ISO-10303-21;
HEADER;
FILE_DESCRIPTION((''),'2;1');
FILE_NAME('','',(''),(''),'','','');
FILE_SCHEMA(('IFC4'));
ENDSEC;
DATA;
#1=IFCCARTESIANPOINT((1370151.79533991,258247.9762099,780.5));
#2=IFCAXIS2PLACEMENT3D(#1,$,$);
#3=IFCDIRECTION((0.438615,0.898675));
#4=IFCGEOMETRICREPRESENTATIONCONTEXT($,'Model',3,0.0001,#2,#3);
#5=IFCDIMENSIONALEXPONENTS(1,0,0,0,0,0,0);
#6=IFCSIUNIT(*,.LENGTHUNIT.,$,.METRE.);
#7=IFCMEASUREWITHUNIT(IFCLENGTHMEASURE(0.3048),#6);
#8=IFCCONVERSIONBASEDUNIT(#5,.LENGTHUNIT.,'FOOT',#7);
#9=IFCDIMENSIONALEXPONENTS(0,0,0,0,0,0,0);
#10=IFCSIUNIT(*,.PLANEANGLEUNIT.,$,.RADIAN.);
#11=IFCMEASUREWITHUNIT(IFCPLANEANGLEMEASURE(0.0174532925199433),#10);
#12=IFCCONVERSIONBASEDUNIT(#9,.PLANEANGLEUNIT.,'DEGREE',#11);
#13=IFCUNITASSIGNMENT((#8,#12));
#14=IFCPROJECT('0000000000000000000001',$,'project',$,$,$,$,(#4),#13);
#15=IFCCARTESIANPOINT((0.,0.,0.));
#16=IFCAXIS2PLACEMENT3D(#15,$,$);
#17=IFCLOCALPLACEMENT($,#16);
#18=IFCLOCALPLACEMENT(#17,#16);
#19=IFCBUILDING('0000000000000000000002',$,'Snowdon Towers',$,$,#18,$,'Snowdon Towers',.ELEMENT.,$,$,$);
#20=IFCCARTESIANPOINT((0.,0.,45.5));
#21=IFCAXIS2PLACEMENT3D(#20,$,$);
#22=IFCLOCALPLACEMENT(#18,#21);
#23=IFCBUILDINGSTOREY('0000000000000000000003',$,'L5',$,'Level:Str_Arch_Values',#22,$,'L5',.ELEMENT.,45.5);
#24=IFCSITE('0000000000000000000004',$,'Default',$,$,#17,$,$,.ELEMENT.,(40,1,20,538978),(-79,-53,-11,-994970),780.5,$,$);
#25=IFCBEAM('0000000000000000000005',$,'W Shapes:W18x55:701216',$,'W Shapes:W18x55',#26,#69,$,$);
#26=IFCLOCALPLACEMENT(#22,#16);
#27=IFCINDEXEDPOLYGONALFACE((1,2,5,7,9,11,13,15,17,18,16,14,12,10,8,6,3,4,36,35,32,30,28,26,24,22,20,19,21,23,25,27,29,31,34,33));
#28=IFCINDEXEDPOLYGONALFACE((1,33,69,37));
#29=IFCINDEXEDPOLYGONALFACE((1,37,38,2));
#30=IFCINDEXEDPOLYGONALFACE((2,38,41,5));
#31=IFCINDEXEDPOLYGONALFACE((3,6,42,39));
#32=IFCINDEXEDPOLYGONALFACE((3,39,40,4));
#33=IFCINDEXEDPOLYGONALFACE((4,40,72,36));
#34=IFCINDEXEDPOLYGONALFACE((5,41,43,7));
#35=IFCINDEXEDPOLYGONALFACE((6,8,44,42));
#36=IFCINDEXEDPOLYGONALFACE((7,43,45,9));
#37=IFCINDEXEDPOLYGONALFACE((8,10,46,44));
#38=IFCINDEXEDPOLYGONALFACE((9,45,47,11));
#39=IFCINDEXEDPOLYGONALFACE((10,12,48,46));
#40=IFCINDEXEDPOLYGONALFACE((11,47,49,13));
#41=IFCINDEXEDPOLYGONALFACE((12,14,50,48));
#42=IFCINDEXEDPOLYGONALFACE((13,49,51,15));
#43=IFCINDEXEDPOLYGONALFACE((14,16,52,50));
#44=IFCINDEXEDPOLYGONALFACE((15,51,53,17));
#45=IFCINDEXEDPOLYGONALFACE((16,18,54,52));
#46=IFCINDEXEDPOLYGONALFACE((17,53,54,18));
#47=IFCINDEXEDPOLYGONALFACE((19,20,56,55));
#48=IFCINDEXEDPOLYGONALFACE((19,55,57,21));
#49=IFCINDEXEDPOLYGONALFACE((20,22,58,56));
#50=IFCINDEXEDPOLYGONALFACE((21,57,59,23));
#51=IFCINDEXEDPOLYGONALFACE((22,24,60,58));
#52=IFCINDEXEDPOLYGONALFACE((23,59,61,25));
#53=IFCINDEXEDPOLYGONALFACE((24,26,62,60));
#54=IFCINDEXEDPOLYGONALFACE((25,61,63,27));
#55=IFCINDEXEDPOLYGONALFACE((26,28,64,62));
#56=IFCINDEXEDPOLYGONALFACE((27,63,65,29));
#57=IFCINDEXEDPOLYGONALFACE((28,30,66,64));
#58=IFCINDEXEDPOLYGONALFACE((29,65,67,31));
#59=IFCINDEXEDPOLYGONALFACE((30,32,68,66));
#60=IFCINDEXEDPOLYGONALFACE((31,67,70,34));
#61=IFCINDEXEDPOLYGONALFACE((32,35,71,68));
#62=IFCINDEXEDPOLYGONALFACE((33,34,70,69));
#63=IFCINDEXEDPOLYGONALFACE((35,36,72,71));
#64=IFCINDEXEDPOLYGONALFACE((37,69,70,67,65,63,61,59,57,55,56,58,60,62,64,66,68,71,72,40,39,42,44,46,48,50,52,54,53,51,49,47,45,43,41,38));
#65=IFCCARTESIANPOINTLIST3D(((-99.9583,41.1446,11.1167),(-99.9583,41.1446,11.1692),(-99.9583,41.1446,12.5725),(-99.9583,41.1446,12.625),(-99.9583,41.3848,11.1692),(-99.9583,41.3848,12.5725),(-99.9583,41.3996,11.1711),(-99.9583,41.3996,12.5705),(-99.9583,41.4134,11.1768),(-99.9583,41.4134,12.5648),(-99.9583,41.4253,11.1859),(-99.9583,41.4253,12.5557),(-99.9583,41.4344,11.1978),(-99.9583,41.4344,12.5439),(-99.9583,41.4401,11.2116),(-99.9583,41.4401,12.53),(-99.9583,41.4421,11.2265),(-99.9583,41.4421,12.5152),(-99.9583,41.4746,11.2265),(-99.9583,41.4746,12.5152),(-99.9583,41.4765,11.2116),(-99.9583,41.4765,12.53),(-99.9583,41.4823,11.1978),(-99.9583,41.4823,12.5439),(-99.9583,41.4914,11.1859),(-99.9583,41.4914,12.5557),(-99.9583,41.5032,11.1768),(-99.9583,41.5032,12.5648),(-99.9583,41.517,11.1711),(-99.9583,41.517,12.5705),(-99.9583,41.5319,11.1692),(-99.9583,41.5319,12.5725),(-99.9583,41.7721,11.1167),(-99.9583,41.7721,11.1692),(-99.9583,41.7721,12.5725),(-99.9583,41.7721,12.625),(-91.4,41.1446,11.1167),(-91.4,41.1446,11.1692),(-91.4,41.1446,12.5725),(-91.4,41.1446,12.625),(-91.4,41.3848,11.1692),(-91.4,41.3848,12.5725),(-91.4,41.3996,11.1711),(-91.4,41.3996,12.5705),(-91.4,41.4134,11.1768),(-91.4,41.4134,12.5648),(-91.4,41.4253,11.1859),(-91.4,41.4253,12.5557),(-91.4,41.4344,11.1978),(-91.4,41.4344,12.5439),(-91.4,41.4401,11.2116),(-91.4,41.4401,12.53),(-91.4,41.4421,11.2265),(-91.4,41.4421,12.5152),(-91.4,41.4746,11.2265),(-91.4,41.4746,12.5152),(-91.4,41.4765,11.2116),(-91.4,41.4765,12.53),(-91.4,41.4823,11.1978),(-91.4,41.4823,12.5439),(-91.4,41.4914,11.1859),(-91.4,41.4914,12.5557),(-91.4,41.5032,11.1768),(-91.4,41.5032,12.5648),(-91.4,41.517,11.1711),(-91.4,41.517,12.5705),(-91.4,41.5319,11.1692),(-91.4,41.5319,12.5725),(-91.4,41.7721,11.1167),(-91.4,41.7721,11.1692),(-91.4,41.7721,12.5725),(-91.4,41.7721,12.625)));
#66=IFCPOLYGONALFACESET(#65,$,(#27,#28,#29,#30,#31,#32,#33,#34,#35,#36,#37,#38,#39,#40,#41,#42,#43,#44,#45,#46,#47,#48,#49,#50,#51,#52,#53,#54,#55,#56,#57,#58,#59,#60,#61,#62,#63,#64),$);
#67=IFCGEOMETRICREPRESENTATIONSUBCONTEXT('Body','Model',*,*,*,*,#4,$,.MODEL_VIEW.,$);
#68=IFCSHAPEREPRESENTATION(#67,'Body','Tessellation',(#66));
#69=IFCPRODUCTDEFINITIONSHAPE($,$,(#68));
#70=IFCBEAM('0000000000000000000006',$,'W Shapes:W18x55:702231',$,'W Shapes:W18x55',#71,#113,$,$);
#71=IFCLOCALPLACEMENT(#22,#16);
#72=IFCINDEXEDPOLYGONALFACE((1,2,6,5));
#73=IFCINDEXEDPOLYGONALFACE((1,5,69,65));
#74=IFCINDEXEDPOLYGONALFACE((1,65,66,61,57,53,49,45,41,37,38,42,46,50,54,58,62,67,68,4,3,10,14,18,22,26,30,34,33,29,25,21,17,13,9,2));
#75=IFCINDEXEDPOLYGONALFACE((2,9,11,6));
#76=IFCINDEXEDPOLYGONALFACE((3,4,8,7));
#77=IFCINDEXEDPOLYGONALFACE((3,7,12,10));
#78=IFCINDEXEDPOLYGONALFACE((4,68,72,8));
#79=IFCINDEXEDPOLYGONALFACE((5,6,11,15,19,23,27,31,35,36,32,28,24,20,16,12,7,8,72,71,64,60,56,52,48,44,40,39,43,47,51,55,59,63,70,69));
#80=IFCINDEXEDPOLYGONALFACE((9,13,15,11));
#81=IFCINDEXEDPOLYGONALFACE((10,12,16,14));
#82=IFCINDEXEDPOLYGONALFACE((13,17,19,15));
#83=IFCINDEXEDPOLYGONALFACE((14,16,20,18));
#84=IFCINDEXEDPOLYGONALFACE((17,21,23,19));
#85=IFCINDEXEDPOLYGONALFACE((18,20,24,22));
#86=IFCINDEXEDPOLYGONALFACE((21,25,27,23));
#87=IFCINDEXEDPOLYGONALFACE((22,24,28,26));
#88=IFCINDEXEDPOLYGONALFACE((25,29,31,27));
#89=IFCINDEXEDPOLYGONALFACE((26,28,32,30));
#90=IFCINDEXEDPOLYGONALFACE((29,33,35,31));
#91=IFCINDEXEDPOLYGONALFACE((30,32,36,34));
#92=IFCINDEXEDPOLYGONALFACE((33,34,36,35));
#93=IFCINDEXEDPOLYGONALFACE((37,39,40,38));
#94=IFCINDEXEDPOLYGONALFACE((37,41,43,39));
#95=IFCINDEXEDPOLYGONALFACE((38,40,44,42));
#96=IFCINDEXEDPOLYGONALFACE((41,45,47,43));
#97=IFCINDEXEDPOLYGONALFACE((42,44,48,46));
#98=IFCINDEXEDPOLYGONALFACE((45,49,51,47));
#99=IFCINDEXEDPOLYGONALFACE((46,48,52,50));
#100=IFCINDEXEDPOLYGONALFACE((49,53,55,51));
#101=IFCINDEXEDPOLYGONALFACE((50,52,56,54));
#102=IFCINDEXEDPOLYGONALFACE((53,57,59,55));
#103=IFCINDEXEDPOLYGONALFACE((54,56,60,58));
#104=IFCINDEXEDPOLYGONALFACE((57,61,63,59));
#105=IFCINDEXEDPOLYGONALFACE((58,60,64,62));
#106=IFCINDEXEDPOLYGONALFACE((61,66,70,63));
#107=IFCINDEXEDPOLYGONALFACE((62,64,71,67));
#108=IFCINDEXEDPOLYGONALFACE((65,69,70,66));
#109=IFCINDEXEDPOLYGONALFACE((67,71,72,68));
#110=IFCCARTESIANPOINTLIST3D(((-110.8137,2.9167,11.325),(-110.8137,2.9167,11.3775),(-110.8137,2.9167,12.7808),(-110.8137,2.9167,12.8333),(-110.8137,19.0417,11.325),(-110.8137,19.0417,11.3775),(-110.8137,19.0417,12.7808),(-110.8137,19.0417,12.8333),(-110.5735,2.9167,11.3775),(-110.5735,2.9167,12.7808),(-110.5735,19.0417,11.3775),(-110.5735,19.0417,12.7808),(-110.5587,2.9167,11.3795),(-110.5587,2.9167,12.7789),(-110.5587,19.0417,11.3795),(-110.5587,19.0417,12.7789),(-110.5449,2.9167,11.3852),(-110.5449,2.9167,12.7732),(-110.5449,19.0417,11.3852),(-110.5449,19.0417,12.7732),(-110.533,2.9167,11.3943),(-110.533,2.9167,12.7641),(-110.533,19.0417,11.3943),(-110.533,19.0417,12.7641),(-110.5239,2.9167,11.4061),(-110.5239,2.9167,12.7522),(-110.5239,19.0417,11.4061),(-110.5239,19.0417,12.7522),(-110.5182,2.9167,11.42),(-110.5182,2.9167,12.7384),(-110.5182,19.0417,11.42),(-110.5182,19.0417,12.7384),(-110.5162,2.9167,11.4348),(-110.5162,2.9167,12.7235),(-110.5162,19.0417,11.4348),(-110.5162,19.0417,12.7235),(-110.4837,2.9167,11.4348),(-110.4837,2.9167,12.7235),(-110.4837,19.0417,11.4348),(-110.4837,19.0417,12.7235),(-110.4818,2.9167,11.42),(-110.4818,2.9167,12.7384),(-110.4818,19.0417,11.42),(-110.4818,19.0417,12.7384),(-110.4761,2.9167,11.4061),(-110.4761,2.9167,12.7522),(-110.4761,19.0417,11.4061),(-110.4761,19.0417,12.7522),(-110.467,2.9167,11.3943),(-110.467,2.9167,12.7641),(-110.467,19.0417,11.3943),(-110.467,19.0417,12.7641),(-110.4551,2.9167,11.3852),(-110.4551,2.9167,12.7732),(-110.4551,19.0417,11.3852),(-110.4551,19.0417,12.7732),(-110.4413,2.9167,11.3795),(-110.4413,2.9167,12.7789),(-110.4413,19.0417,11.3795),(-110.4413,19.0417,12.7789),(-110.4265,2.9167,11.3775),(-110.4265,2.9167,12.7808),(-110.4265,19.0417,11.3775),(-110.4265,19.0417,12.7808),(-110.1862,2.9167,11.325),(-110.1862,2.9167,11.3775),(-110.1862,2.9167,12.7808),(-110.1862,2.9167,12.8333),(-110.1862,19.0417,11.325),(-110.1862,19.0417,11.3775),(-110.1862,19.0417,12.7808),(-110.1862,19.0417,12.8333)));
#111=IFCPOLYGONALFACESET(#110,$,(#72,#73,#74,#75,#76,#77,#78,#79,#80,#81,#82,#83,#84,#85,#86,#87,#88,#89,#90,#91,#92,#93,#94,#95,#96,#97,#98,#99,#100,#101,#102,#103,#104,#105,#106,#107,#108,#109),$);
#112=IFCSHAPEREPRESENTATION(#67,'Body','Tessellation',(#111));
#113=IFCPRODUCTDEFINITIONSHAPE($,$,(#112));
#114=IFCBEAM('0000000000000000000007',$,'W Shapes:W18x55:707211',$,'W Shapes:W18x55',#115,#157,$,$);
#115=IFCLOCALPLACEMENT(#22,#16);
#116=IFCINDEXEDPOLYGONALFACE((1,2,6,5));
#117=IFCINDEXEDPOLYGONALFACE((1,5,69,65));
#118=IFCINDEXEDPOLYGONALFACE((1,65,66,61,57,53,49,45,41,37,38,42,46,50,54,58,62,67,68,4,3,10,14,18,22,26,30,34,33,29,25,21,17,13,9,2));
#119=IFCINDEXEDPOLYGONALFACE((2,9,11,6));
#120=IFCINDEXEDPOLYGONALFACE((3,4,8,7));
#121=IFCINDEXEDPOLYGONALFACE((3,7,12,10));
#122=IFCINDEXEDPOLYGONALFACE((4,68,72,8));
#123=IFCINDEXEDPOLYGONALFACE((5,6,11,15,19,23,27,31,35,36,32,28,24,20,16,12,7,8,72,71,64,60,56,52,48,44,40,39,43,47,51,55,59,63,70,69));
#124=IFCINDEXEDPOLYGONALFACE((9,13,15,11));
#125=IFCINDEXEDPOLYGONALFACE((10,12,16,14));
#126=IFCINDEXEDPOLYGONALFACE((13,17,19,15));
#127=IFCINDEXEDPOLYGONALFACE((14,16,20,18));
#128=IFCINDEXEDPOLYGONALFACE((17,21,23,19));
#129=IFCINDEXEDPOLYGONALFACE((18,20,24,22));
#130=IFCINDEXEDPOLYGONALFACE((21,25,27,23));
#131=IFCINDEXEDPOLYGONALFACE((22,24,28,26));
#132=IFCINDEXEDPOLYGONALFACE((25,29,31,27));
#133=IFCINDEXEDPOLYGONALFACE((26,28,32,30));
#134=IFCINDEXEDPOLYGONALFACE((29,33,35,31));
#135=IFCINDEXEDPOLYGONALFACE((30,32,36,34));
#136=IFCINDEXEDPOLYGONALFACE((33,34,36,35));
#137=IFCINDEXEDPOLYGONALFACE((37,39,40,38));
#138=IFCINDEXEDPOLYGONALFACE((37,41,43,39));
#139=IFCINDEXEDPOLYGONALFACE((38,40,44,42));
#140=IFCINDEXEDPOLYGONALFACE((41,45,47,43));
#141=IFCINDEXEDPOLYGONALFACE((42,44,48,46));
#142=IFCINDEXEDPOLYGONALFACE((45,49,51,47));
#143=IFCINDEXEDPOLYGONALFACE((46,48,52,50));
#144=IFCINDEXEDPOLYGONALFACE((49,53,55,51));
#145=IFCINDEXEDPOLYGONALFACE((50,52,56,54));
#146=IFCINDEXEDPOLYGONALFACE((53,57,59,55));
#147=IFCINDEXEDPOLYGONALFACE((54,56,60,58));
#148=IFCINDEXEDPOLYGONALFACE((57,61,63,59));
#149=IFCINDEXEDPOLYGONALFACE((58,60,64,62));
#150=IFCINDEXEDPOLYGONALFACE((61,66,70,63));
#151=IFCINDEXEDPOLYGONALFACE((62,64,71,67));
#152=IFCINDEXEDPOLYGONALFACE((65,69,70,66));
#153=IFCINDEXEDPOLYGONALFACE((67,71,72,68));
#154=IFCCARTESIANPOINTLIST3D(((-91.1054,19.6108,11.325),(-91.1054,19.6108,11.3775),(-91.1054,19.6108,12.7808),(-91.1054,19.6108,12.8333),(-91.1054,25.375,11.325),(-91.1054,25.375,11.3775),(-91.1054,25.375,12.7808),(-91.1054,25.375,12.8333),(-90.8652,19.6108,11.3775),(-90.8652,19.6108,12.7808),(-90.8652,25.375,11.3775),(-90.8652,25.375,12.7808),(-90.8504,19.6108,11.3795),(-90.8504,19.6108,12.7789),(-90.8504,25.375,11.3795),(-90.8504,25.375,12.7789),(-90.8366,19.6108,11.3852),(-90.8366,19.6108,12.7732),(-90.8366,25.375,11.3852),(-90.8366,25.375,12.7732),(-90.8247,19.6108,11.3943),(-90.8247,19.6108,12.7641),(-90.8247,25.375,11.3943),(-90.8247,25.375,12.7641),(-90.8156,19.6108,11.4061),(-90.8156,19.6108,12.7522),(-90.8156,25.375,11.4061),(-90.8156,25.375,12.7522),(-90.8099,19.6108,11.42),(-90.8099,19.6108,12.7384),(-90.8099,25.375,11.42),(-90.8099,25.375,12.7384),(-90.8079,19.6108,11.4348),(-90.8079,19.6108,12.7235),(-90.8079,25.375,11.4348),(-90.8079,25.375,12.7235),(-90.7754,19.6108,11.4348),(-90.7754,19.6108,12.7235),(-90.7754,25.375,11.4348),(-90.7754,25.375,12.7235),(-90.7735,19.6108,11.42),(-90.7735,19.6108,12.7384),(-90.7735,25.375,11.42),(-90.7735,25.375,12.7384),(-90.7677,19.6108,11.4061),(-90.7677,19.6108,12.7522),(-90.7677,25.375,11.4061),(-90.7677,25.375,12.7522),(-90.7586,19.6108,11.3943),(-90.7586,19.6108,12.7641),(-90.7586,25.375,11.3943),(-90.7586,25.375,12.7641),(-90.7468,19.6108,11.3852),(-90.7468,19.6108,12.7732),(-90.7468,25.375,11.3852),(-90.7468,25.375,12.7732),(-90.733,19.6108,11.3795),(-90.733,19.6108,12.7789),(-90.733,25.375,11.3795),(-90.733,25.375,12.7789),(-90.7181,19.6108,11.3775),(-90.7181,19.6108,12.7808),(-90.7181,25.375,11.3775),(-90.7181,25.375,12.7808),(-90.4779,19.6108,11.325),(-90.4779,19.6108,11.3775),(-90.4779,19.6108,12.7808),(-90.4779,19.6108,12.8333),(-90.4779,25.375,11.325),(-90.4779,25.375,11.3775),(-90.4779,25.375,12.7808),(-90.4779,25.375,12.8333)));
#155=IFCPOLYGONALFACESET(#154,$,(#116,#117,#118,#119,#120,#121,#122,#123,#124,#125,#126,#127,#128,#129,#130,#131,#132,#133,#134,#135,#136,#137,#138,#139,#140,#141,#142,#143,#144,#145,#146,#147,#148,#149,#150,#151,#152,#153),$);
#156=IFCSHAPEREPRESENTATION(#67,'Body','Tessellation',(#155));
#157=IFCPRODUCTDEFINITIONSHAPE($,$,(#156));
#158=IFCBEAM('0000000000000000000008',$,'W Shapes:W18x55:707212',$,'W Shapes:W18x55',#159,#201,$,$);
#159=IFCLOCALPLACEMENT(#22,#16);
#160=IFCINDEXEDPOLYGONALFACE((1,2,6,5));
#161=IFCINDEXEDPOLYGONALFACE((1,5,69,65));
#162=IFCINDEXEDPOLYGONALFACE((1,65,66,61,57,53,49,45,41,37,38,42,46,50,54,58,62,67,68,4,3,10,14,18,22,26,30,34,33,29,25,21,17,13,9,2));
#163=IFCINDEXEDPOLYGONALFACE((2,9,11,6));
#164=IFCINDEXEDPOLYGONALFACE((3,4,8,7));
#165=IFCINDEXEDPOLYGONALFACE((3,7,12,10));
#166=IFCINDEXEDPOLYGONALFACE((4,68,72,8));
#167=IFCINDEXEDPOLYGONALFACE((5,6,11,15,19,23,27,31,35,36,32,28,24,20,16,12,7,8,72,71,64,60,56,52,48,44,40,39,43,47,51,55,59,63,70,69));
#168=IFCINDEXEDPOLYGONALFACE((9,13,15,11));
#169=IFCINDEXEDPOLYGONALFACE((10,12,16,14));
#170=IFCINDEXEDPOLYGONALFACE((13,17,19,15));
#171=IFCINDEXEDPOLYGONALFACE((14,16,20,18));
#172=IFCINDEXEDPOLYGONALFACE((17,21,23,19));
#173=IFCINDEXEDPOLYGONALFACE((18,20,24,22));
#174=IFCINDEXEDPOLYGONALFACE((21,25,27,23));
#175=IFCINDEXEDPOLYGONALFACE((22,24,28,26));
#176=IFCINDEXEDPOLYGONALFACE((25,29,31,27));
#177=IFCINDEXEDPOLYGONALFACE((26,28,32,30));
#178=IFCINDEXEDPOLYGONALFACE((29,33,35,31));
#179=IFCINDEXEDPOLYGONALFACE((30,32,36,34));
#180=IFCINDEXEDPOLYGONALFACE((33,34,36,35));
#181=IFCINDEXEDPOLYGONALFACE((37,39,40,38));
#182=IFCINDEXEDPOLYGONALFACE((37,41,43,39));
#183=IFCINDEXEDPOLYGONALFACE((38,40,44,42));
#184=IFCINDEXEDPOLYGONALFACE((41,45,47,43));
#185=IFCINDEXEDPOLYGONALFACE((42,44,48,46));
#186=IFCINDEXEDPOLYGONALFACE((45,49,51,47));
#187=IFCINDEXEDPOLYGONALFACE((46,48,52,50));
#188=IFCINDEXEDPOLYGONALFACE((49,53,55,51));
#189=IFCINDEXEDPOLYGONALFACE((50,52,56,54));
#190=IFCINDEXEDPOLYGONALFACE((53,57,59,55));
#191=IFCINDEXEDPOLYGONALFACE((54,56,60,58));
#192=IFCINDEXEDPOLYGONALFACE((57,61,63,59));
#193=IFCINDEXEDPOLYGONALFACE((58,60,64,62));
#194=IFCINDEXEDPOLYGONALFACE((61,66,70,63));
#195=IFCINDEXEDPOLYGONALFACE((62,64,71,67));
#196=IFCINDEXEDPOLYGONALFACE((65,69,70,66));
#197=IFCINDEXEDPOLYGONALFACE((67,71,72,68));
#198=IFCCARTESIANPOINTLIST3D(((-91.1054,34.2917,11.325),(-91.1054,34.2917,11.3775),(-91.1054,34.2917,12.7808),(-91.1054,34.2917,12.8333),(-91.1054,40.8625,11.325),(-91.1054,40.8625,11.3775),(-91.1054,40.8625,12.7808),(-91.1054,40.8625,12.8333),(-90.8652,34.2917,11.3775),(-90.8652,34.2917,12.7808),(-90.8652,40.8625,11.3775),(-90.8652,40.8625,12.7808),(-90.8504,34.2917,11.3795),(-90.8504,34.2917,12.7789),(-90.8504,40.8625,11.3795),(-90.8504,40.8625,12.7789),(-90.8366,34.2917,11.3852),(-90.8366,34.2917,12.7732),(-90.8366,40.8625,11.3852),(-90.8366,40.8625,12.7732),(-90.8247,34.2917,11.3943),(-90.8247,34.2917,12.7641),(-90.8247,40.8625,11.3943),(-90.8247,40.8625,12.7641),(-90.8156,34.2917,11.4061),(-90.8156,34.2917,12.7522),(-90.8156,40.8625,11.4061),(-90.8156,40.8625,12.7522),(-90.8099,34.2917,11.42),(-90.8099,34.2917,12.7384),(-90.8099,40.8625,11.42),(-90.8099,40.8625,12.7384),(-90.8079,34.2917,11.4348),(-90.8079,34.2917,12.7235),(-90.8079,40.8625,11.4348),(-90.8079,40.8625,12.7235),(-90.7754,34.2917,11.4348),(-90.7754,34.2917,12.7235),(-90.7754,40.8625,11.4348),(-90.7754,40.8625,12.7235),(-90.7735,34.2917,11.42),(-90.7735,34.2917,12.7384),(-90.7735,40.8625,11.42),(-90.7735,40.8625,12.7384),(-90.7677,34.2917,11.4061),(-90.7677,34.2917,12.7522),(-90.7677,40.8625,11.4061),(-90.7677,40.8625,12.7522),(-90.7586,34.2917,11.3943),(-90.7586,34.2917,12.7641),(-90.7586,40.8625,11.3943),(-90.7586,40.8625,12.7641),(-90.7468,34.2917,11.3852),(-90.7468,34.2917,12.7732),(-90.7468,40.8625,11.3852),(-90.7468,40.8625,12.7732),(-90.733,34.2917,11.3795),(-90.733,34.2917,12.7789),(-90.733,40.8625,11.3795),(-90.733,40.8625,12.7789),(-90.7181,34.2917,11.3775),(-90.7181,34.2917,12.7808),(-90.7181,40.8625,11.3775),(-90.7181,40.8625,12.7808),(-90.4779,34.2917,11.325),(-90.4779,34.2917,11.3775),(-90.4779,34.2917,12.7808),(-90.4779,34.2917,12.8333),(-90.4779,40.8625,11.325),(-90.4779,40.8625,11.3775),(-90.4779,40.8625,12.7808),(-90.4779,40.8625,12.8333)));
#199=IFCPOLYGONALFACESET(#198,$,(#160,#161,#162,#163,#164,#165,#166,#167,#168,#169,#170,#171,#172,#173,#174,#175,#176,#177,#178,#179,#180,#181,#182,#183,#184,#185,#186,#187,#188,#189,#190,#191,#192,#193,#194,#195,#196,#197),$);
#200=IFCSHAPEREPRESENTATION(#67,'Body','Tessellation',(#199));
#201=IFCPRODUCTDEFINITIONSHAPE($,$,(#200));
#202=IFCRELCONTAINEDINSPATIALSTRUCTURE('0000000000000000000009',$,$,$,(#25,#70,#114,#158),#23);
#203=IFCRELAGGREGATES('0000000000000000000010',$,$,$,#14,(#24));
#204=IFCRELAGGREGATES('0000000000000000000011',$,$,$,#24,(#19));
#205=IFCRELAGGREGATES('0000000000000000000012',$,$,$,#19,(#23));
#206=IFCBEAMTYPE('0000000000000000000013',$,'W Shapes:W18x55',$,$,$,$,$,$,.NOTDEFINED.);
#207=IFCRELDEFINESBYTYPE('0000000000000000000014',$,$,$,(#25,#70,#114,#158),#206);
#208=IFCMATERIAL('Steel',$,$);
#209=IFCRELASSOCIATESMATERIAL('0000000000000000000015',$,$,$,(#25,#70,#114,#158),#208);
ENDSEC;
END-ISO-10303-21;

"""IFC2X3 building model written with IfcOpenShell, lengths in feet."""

from ifc_helpers import new_model, entity, si_unit, converted_unit, direction, frame, frame_2d, origin, place, context, subcontext, project, spatial, i_section, extrude, material, type_object, element, save


model = new_model("IFC2X3")

# Units and contexts
model_context = context("Model", 3, precision=0.0001, world=frame((1370151.79533991, 258247.9762099, 780.5)), true_north=direction((0.438615, 0.898675)))
body_context = subcontext(model_context, "Body", "Model", "MODEL_VIEW")
ifc_project = project(units=[converted_unit("LENGTHUNIT", "FOOT", entity("IfcLengthMeasure", 0.3048), si_unit("LENGTHUNIT", "METRE"), dimensions=[1, 0, 0, 0, 0, 0, 0]), converted_unit("PLANEANGLEUNIT", "DEGREE", entity("IfcPlaneAngleMeasure", 0.0174532925199433), si_unit("PLANEANGLEUNIT", "RADIAN"), dimensions=[0, 0, 0, 0, 0, 0, 0])], contexts=[model_context])

# Site, building, storey
site_placement = place(None, origin())
site = spatial("IfcSite", under=ifc_project, at=site_placement, Name="Default", CompositionType="ELEMENT", RefLatitude=(40, 1, 20, 538978), RefLongitude=(-79, -53, -11, -994970), RefElevation=780.5)
building_placement = place(site_placement, origin())
building = spatial("IfcBuilding", under=site, at=building_placement, Name="Snowdon Towers", LongName="Snowdon Towers", CompositionType="ELEMENT")
storey_placement = place(building_placement, frame((0.0, 0.0, 45.5)))
storey = spatial("IfcBuildingStorey", under=building, at=storey_placement, Name="L5", ObjectType="Level:Str_Arch_Values", LongName="L5", CompositionType="ELEMENT", Elevation=45.5)

# Beams
ifc_material = material(Name="Steel")
beam_type_1 = type_object("IfcBeamType", Name="W Shapes:W18x55", PredefinedType="NOTDEFINED")
beam_1_placement = place(storey_placement, frame((-99.9583, 41.4583, 12.8333)))
element("IfcBeam", 1, at=beam_1_placement, inside=storey, type_object=beam_type_1, material=ifc_material, Name="W Shapes:W18x55:701216", ObjectType="W Shapes:W18x55", context=body_context, shape_type="SweptSolid", body=[
    extrude(i_section(OverallWidth=0.6275, OverallDepth=1.5083, WebThickness=0.0325, FlangeThickness=0.0525, FilletRadius=0.0573, at=frame_2d((0.0, 0.0), x_axis=(0.0, 1.0))), frame((0.0, 0.0, -0.9625), z_axis=(1.0, 0.0, 0.0), x_axis=(0.0, 0.0, -1.0)), (0.0, 0.0, 1.0), 8.5583),
])
beam_2_placement = place(storey_placement, frame((-110.5, 2.5, 12.8333), z_axis=(0.0, 0.0, 1.0), x_axis=(0.0, 1.0, 0.0)))
element("IfcBeam", 2, at=beam_2_placement, inside=storey, type_object=beam_type_1, material=ifc_material, Name="W Shapes:W18x55:702231", ObjectType="W Shapes:W18x55", context=body_context, shape_type="SweptSolid", body=[
    extrude(i_section(OverallWidth=0.6275, OverallDepth=1.5083, WebThickness=0.0325, FlangeThickness=0.0525, FilletRadius=0.0573, at=frame_2d((0.0, 0.0), x_axis=(0.0, 1.0))), frame((0.4167, 0.0, -0.7542), z_axis=(1.0, 0.0, 0.0), x_axis=(0.0, 0.0, -1.0)), (0.0, 0.0, 1.0), 16.125),
])
beam_3_placement = place(storey_placement, frame((-90.7917, 19.1942, 12.8333), z_axis=(0.0, 0.0, 1.0), x_axis=(0.0, 1.0, 0.0)))
element("IfcBeam", 3, at=beam_3_placement, inside=storey, type_object=beam_type_1, material=ifc_material, Name="W Shapes:W18x55:707211", ObjectType="W Shapes:W18x55", context=body_context, shape_type="SweptSolid", body=[
    extrude(i_section(OverallWidth=0.6275, OverallDepth=1.5083, WebThickness=0.0325, FlangeThickness=0.0525, FilletRadius=0.0573, at=frame_2d((0.0, 0.0), x_axis=(0.0, 1.0))), frame((0.4167, 0.0, -0.7542), z_axis=(1.0, 0.0, 0.0), x_axis=(0.0, 0.0, -1.0)), (0.0, 0.0, 1.0), 5.7642),
])
beam_4_placement = place(storey_placement, frame((-90.7917, 41.4583, 12.8333), z_axis=(0.0, 0.0, 1.0), x_axis=(0.0, -1.0, 0.0)))
element("IfcBeam", 4, at=beam_4_placement, inside=storey, type_object=beam_type_1, material=ifc_material, Name="W Shapes:W18x55:707212", ObjectType="W Shapes:W18x55", context=body_context, shape_type="SweptSolid", body=[
    extrude(i_section(OverallWidth=0.6275, OverallDepth=1.5083, WebThickness=0.0325, FlangeThickness=0.0525, FilletRadius=0.0573, at=frame_2d((0.0, 0.0), x_axis=(0.0, 1.0))), frame((0.5958, 0.0, -0.7542), z_axis=(1.0, 0.0, 0.0), x_axis=(0.0, 0.0, -1.0)), (0.0, 0.0, 1.0), 6.5708),
])

save(model, "model.ifc")
